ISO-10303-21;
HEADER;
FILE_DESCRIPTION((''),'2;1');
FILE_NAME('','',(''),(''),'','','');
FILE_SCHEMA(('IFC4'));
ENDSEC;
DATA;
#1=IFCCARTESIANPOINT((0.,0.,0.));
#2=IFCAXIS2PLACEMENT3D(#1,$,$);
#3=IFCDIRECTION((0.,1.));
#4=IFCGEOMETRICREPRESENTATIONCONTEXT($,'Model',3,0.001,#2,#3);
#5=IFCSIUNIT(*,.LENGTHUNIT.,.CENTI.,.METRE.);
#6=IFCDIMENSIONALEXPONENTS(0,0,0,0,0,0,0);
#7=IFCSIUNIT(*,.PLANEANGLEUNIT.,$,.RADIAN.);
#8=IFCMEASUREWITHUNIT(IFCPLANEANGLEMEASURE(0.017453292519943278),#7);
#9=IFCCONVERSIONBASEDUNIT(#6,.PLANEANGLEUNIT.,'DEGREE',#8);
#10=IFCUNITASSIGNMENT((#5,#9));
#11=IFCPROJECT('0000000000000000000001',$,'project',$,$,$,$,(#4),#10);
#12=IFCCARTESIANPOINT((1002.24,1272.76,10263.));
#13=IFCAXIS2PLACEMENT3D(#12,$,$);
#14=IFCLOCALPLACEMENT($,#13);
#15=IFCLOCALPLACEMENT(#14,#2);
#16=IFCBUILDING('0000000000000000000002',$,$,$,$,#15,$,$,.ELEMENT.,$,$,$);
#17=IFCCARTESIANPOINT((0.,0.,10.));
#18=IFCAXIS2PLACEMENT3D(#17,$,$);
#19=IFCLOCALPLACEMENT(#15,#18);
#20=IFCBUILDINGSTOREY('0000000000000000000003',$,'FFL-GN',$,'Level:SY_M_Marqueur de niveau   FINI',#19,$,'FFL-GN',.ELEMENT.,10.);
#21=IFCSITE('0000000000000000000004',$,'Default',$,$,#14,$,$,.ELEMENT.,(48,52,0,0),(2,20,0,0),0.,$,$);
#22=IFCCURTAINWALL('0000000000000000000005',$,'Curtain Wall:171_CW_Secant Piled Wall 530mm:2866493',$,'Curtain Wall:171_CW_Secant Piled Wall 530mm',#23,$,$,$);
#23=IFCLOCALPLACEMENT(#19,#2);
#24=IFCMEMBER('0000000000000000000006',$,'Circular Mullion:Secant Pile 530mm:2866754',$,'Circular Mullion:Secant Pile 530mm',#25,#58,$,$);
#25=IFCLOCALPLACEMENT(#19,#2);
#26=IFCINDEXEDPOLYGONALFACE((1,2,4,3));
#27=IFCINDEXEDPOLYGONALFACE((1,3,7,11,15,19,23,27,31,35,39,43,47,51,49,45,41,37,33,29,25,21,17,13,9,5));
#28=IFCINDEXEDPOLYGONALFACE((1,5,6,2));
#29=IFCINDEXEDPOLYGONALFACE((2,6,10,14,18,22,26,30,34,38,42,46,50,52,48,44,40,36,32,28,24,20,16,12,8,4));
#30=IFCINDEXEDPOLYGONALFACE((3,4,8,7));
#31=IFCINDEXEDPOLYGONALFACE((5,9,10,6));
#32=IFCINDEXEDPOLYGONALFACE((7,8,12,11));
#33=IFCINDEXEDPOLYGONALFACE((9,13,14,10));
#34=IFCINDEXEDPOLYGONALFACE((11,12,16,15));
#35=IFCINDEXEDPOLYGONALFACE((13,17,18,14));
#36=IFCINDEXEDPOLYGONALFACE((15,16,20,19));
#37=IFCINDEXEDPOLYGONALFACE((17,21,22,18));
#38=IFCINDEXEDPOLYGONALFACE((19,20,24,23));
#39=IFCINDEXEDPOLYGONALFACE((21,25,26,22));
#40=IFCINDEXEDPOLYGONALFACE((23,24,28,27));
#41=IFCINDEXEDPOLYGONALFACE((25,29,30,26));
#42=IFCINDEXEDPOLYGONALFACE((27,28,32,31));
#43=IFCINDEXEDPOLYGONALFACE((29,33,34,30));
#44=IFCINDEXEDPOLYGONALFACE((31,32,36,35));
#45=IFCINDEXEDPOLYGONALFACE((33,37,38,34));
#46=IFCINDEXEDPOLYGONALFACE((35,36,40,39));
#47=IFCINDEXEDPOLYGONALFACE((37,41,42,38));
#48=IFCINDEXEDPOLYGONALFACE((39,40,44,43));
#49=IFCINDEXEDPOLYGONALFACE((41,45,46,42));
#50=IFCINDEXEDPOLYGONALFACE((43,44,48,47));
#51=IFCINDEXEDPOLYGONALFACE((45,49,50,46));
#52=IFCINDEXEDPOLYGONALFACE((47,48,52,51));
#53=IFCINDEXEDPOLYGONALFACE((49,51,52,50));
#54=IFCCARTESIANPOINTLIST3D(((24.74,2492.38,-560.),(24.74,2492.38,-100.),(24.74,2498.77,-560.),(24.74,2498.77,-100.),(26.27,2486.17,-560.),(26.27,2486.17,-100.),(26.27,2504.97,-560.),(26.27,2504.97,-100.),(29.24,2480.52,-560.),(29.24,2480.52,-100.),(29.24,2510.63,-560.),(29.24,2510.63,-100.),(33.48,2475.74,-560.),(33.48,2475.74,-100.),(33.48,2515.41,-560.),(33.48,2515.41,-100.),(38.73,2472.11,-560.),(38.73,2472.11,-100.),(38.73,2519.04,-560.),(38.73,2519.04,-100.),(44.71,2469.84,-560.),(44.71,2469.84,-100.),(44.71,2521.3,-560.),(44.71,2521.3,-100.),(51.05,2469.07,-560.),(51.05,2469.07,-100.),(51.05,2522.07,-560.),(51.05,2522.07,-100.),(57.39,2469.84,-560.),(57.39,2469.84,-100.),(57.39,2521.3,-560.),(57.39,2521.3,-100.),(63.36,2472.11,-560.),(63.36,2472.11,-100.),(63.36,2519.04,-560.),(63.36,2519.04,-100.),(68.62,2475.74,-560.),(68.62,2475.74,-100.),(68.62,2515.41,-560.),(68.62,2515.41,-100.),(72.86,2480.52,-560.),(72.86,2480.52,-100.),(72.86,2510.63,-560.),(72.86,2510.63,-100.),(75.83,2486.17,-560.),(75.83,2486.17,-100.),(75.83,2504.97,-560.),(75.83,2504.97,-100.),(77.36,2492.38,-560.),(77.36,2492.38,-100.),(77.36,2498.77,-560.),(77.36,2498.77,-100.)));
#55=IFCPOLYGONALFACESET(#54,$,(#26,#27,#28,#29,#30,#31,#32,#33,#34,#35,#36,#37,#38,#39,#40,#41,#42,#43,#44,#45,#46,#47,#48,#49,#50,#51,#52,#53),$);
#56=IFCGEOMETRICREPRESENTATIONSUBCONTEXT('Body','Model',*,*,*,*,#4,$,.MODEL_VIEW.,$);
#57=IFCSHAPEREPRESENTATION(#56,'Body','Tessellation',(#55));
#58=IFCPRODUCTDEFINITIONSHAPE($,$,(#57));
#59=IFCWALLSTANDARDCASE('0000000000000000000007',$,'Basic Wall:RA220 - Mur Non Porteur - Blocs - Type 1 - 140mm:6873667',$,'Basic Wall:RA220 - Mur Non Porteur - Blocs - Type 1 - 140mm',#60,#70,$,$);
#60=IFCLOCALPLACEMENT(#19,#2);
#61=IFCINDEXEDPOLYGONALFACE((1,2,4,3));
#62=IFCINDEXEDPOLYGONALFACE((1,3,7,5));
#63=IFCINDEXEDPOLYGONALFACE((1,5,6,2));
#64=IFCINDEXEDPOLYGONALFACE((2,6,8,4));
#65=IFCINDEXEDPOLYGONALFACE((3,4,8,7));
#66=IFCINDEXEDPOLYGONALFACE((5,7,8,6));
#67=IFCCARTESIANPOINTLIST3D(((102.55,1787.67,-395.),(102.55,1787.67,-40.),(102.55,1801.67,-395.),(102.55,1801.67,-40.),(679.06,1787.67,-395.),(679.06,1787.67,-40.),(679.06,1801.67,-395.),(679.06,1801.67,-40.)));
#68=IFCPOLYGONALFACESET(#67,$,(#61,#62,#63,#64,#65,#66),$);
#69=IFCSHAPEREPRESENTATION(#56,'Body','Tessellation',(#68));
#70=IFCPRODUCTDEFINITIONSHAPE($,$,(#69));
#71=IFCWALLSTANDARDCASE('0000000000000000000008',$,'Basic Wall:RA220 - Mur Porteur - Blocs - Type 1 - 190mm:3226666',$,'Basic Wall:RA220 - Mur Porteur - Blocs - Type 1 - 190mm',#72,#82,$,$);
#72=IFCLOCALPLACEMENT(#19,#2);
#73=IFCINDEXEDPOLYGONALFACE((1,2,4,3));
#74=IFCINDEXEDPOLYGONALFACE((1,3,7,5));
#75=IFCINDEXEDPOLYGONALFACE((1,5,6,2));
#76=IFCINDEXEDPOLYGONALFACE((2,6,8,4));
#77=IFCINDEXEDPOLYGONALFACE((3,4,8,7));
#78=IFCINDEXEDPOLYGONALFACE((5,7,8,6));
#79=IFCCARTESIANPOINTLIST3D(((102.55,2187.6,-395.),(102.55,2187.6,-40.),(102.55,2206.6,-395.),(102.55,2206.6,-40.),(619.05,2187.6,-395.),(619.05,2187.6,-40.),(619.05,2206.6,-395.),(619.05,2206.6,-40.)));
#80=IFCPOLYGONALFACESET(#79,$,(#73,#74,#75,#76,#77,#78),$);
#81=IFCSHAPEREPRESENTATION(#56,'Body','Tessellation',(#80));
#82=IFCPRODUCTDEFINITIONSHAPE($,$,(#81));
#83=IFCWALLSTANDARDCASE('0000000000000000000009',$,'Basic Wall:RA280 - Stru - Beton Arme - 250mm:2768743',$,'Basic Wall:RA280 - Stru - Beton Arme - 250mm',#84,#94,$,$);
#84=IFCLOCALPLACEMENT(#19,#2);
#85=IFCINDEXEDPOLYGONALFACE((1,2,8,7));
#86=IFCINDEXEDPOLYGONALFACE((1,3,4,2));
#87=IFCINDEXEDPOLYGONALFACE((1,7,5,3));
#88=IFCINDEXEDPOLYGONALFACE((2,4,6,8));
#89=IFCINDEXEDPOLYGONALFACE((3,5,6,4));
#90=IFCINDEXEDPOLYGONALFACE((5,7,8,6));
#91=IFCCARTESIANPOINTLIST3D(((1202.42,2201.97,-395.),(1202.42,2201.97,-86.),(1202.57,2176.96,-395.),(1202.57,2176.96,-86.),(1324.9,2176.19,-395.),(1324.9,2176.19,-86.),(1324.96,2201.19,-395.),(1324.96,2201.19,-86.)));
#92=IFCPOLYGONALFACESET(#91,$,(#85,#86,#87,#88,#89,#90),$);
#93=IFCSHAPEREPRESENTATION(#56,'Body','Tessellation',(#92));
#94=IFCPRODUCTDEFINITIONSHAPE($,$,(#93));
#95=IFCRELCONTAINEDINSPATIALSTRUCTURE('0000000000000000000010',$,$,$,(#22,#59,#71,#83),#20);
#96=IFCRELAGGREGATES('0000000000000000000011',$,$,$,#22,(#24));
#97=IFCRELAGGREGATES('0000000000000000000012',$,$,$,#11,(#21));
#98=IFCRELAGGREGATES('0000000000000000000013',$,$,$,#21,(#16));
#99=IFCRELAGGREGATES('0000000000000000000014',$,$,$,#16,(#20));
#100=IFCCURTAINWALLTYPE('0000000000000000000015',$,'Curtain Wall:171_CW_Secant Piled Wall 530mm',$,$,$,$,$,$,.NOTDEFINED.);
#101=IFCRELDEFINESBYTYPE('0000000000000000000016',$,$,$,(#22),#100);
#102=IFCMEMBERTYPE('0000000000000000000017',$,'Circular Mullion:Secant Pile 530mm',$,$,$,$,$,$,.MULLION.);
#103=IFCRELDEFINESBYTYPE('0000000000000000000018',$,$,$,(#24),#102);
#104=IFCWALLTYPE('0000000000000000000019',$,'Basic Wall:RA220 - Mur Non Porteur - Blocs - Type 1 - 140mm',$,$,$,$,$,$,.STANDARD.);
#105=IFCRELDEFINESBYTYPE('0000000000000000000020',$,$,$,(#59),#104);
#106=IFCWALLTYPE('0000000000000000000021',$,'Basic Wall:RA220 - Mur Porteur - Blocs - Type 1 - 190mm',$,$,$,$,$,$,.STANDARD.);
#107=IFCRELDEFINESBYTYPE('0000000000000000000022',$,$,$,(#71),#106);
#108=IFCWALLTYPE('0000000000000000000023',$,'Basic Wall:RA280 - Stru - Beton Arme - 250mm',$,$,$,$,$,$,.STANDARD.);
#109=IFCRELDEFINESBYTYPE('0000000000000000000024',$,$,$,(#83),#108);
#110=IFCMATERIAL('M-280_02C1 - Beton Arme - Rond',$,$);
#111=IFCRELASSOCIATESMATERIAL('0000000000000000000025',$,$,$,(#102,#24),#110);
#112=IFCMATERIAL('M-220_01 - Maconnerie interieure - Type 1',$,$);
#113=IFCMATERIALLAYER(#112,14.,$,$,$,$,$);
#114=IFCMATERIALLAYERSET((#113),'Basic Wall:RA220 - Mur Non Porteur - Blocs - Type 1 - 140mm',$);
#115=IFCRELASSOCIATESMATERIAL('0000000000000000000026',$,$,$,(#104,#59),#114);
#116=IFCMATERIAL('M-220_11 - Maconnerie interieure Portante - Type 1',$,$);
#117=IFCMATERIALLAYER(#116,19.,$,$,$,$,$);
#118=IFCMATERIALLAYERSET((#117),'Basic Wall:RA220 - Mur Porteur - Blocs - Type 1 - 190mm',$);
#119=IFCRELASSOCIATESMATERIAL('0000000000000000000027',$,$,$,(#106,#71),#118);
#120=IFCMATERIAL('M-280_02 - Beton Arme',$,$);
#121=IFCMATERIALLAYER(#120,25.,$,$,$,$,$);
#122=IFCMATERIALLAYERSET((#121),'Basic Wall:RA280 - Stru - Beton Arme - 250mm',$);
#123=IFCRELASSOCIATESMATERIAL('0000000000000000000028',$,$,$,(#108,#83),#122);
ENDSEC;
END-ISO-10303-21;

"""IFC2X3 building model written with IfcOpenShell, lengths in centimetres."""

from ifc_helpers import new_model, entity, si_unit, converted_unit, direction, frame, frame_2d, origin, place, context, subcontext, project, spatial, polyline, rectangle, circle, outline, extrude, clip, bounded_halfspace, source, transform, mapped, material, layer, layer_set, layer_usage, type_object, type_shapes, element, aggregate, save


model = new_model("IFC2X3")

# Units and contexts
model_context = context("Model", 3, precision=0.001, world=origin(), true_north=direction((0.0, 1.0)))
body_context = subcontext(model_context, "Body", "Model", "MODEL_VIEW")
ifc_project = project(units=[si_unit("LENGTHUNIT", "METRE", prefix="CENTI"), converted_unit("PLANEANGLEUNIT", "DEGREE", entity("IfcPlaneAngleMeasure", 0.017453292519943278), si_unit("PLANEANGLEUNIT", "RADIAN"), dimensions=[0, 0, 0, 0, 0, 0, 0])], contexts=[model_context])

# Site, building, storey
site_placement = place(None, frame((1002.24, 1272.76, 10263.0)))
site = spatial("IfcSite", under=ifc_project, at=site_placement, Name="Default", CompositionType="ELEMENT", RefLatitude=(48, 52, 0, 0), RefLongitude=(2, 20, 0, 0), RefElevation=0.0)
building_placement = place(site_placement, origin())
building = spatial("IfcBuilding", under=site, at=building_placement, CompositionType="ELEMENT")
storey_placement = place(building_placement, frame((0.0, 0.0, 10.0)))
storey = spatial("IfcBuildingStorey", under=building, at=storey_placement, Name="FFL-GN", ObjectType="Level:SY_M_Marqueur de niveau   FINI", LongName="FFL-GN", CompositionType="ELEMENT", Elevation=10.0)

# Curtain wall, member
curtain_wall_type = type_object("IfcCurtainWallType", Name="Curtain Wall:171_CW_Secant Piled Wall 530mm", PredefinedType="NOTDEFINED")
curtain_wall_placement = place(storey_placement, frame((0.0, 0.0, -10.0)))
curtain_wall = element("IfcCurtainWall", 1, at=curtain_wall_placement, inside=storey, type_object=curtain_wall_type, Name="Curtain Wall:171_CW_Secant Piled Wall 530mm:2866493", ObjectType="Curtain Wall:171_CW_Secant Piled Wall 530mm")
ifc_material_1 = material(Name="M-280_02C1 - Beton Arme - Rond")
member_type = type_object("IfcMemberType", Name="Circular Mullion:Secant Pile 530mm", PredefinedType="MULLION", material=ifc_material_1)
shared_shape = source(origin(), body_context, "Body", "SweptSolid", [
    extrude(circle(Radius=26.5, at=frame_2d((0.0, 0.0), x_axis=(1.0, 0.0))), frame((0.0, 0.0, -460.0)), (0.0, 0.0, 1.0), 460.0),
])
type_shapes(member_type, [shared_shape])
member_1_placement = place(curtain_wall_placement, frame((51.05, 2495.57, -550.0), z_axis=(0.0, 0.0, -1.0), x_axis=(0.0, 1.0, 0.0)))
member_1 = element("IfcMember", 2, at=member_1_placement, type_object=member_type, material=ifc_material_1, Name="Circular Mullion:Secant Pile 530mm:2866754", ObjectType="Circular Mullion:Secant Pile 530mm", context=body_context, shape_type="MappedRepresentation", body=[
    mapped(shared_shape, transform((0.0, 0.0, 0.0), scale=1.0)),
])
aggregate(curtain_wall, [member_1])

# Walls
ifc_material_2 = material(Name="M-220_01 - Maconnerie interieure - Type 1")
ifc_layer_1 = layer(ifc_material_2, 14.0)
ifc_layer_set_1 = layer_set([ifc_layer_1], Name="Basic Wall:RA220 - Mur Non Porteur - Blocs - Type 1 - 140mm")
ifc_layer_usage_1 = layer_usage(ifc_layer_set_1, "AXIS2", "NEGATIVE", 7.0)
wall_type_1 = type_object("IfcWallType", Name="Basic Wall:RA220 - Mur Non Porteur - Blocs - Type 1 - 140mm", PredefinedType="STANDARD", material=ifc_layer_set_1)
wall_1_placement = place(storey_placement, frame((102.55, 1794.67, -395.0)))
element("IfcWallStandardCase", 3, at=wall_1_placement, inside=storey, type_object=wall_type_1, material=ifc_layer_usage_1, Name="Basic Wall:RA220 - Mur Non Porteur - Blocs - Type 1 - 140mm:6873667", ObjectType="Basic Wall:RA220 - Mur Non Porteur - Blocs - Type 1 - 140mm", context=body_context, shape_type="SweptSolid", body=[
    extrude(rectangle(XDim=576.51, YDim=14.0, at=frame_2d((288.25, 0.0), x_axis=(-1.0, 0.0))), origin(), (0.0, 0.0, 1.0), 355.0),
])
ifc_material_3 = material(Name="M-220_11 - Maconnerie interieure Portante - Type 1")
ifc_layer_2 = layer(ifc_material_3, 19.0)
ifc_layer_set_2 = layer_set([ifc_layer_2], Name="Basic Wall:RA220 - Mur Porteur - Blocs - Type 1 - 190mm")
ifc_layer_usage_2 = layer_usage(ifc_layer_set_2, "AXIS2", "NEGATIVE", 9.5)
wall_type_2 = type_object("IfcWallType", Name="Basic Wall:RA220 - Mur Porteur - Blocs - Type 1 - 190mm", PredefinedType="STANDARD", material=ifc_layer_set_2)
wall_2_placement = place(storey_placement, frame((102.55, 2197.1, -395.0)))
element("IfcWallStandardCase", 4, at=wall_2_placement, inside=storey, type_object=wall_type_2, material=ifc_layer_usage_2, Name="Basic Wall:RA220 - Mur Porteur - Blocs - Type 1 - 190mm:3226666", ObjectType="Basic Wall:RA220 - Mur Porteur - Blocs - Type 1 - 190mm", context=body_context, shape_type="Clipping", body=[
    clip(extrude(rectangle(XDim=516.5, YDim=19.0, at=frame_2d((258.25, 0.0), x_axis=(-1.0, 0.0))), origin(), (0.0, 0.0, 1.0), 355.0), bounded_halfspace(frame((0.0, -9.5, 355.0), z_axis=(0.0, 0.0, -1.0), x_axis=(1.0, 0.0, 0.0)), True, frame((0.0, -9.5, 355.0), z_axis=(0.0, 0.0, -1.0), x_axis=(1.0, 0.0, 0.0)), polyline([(0.0, 0.0), (0.0, -19.0), (516.5, -19.0), (516.5, 0.0), (0.0, 0.0)]))),
])
ifc_material_4 = material(Name="M-280_02 - Beton Arme")
ifc_layer_3 = layer(ifc_material_4, 25.0)
ifc_layer_set_3 = layer_set([ifc_layer_3], Name="Basic Wall:RA280 - Stru - Beton Arme - 250mm")
ifc_layer_usage_3 = layer_usage(ifc_layer_set_3, "AXIS2", "NEGATIVE", 12.5)
wall_type_3 = type_object("IfcWallType", Name="Basic Wall:RA280 - Stru - Beton Arme - 250mm", PredefinedType="STANDARD", material=ifc_layer_set_3)
wall_3_placement = place(storey_placement, frame((1202.34, 2189.47, -395.0), z_axis=(0.0, 0.0, 1.0), x_axis=(0.99998, -0.006355, 0.0)))
element("IfcWallStandardCase", 5, at=wall_3_placement, inside=storey, type_object=wall_type_3, material=ifc_layer_usage_3, Name="Basic Wall:RA280 - Stru - Beton Arme - 250mm:2768743", ObjectType="Basic Wall:RA280 - Stru - Beton Arme - 250mm", context=body_context, shape_type="Clipping", body=[
    clip(extrude(outline(polyline([(122.64, -12.5), (122.54, 12.5), (25.0, 12.5), (0.0, 12.5), (0.31, -12.5), (97.64, -12.5), (122.64, -12.5)])), origin(), (0.0, 0.0, 1.0), 309.0), bounded_halfspace(frame((122.64, -12.5, 309.0), z_axis=(0.0, 0.0, -1.0), x_axis=(0.006355, -0.99998, 0.0)), True, frame((122.64, -12.5, 309.0)), polyline([(0.0, 0.0), (-0.1, 25.0), (-97.64, 25.0), (-121.55, 25.0), (-121.2, 0.0), (-25.0, 0.0), (0.0, 0.0)]))),
])

save(model, "model.ifc")
